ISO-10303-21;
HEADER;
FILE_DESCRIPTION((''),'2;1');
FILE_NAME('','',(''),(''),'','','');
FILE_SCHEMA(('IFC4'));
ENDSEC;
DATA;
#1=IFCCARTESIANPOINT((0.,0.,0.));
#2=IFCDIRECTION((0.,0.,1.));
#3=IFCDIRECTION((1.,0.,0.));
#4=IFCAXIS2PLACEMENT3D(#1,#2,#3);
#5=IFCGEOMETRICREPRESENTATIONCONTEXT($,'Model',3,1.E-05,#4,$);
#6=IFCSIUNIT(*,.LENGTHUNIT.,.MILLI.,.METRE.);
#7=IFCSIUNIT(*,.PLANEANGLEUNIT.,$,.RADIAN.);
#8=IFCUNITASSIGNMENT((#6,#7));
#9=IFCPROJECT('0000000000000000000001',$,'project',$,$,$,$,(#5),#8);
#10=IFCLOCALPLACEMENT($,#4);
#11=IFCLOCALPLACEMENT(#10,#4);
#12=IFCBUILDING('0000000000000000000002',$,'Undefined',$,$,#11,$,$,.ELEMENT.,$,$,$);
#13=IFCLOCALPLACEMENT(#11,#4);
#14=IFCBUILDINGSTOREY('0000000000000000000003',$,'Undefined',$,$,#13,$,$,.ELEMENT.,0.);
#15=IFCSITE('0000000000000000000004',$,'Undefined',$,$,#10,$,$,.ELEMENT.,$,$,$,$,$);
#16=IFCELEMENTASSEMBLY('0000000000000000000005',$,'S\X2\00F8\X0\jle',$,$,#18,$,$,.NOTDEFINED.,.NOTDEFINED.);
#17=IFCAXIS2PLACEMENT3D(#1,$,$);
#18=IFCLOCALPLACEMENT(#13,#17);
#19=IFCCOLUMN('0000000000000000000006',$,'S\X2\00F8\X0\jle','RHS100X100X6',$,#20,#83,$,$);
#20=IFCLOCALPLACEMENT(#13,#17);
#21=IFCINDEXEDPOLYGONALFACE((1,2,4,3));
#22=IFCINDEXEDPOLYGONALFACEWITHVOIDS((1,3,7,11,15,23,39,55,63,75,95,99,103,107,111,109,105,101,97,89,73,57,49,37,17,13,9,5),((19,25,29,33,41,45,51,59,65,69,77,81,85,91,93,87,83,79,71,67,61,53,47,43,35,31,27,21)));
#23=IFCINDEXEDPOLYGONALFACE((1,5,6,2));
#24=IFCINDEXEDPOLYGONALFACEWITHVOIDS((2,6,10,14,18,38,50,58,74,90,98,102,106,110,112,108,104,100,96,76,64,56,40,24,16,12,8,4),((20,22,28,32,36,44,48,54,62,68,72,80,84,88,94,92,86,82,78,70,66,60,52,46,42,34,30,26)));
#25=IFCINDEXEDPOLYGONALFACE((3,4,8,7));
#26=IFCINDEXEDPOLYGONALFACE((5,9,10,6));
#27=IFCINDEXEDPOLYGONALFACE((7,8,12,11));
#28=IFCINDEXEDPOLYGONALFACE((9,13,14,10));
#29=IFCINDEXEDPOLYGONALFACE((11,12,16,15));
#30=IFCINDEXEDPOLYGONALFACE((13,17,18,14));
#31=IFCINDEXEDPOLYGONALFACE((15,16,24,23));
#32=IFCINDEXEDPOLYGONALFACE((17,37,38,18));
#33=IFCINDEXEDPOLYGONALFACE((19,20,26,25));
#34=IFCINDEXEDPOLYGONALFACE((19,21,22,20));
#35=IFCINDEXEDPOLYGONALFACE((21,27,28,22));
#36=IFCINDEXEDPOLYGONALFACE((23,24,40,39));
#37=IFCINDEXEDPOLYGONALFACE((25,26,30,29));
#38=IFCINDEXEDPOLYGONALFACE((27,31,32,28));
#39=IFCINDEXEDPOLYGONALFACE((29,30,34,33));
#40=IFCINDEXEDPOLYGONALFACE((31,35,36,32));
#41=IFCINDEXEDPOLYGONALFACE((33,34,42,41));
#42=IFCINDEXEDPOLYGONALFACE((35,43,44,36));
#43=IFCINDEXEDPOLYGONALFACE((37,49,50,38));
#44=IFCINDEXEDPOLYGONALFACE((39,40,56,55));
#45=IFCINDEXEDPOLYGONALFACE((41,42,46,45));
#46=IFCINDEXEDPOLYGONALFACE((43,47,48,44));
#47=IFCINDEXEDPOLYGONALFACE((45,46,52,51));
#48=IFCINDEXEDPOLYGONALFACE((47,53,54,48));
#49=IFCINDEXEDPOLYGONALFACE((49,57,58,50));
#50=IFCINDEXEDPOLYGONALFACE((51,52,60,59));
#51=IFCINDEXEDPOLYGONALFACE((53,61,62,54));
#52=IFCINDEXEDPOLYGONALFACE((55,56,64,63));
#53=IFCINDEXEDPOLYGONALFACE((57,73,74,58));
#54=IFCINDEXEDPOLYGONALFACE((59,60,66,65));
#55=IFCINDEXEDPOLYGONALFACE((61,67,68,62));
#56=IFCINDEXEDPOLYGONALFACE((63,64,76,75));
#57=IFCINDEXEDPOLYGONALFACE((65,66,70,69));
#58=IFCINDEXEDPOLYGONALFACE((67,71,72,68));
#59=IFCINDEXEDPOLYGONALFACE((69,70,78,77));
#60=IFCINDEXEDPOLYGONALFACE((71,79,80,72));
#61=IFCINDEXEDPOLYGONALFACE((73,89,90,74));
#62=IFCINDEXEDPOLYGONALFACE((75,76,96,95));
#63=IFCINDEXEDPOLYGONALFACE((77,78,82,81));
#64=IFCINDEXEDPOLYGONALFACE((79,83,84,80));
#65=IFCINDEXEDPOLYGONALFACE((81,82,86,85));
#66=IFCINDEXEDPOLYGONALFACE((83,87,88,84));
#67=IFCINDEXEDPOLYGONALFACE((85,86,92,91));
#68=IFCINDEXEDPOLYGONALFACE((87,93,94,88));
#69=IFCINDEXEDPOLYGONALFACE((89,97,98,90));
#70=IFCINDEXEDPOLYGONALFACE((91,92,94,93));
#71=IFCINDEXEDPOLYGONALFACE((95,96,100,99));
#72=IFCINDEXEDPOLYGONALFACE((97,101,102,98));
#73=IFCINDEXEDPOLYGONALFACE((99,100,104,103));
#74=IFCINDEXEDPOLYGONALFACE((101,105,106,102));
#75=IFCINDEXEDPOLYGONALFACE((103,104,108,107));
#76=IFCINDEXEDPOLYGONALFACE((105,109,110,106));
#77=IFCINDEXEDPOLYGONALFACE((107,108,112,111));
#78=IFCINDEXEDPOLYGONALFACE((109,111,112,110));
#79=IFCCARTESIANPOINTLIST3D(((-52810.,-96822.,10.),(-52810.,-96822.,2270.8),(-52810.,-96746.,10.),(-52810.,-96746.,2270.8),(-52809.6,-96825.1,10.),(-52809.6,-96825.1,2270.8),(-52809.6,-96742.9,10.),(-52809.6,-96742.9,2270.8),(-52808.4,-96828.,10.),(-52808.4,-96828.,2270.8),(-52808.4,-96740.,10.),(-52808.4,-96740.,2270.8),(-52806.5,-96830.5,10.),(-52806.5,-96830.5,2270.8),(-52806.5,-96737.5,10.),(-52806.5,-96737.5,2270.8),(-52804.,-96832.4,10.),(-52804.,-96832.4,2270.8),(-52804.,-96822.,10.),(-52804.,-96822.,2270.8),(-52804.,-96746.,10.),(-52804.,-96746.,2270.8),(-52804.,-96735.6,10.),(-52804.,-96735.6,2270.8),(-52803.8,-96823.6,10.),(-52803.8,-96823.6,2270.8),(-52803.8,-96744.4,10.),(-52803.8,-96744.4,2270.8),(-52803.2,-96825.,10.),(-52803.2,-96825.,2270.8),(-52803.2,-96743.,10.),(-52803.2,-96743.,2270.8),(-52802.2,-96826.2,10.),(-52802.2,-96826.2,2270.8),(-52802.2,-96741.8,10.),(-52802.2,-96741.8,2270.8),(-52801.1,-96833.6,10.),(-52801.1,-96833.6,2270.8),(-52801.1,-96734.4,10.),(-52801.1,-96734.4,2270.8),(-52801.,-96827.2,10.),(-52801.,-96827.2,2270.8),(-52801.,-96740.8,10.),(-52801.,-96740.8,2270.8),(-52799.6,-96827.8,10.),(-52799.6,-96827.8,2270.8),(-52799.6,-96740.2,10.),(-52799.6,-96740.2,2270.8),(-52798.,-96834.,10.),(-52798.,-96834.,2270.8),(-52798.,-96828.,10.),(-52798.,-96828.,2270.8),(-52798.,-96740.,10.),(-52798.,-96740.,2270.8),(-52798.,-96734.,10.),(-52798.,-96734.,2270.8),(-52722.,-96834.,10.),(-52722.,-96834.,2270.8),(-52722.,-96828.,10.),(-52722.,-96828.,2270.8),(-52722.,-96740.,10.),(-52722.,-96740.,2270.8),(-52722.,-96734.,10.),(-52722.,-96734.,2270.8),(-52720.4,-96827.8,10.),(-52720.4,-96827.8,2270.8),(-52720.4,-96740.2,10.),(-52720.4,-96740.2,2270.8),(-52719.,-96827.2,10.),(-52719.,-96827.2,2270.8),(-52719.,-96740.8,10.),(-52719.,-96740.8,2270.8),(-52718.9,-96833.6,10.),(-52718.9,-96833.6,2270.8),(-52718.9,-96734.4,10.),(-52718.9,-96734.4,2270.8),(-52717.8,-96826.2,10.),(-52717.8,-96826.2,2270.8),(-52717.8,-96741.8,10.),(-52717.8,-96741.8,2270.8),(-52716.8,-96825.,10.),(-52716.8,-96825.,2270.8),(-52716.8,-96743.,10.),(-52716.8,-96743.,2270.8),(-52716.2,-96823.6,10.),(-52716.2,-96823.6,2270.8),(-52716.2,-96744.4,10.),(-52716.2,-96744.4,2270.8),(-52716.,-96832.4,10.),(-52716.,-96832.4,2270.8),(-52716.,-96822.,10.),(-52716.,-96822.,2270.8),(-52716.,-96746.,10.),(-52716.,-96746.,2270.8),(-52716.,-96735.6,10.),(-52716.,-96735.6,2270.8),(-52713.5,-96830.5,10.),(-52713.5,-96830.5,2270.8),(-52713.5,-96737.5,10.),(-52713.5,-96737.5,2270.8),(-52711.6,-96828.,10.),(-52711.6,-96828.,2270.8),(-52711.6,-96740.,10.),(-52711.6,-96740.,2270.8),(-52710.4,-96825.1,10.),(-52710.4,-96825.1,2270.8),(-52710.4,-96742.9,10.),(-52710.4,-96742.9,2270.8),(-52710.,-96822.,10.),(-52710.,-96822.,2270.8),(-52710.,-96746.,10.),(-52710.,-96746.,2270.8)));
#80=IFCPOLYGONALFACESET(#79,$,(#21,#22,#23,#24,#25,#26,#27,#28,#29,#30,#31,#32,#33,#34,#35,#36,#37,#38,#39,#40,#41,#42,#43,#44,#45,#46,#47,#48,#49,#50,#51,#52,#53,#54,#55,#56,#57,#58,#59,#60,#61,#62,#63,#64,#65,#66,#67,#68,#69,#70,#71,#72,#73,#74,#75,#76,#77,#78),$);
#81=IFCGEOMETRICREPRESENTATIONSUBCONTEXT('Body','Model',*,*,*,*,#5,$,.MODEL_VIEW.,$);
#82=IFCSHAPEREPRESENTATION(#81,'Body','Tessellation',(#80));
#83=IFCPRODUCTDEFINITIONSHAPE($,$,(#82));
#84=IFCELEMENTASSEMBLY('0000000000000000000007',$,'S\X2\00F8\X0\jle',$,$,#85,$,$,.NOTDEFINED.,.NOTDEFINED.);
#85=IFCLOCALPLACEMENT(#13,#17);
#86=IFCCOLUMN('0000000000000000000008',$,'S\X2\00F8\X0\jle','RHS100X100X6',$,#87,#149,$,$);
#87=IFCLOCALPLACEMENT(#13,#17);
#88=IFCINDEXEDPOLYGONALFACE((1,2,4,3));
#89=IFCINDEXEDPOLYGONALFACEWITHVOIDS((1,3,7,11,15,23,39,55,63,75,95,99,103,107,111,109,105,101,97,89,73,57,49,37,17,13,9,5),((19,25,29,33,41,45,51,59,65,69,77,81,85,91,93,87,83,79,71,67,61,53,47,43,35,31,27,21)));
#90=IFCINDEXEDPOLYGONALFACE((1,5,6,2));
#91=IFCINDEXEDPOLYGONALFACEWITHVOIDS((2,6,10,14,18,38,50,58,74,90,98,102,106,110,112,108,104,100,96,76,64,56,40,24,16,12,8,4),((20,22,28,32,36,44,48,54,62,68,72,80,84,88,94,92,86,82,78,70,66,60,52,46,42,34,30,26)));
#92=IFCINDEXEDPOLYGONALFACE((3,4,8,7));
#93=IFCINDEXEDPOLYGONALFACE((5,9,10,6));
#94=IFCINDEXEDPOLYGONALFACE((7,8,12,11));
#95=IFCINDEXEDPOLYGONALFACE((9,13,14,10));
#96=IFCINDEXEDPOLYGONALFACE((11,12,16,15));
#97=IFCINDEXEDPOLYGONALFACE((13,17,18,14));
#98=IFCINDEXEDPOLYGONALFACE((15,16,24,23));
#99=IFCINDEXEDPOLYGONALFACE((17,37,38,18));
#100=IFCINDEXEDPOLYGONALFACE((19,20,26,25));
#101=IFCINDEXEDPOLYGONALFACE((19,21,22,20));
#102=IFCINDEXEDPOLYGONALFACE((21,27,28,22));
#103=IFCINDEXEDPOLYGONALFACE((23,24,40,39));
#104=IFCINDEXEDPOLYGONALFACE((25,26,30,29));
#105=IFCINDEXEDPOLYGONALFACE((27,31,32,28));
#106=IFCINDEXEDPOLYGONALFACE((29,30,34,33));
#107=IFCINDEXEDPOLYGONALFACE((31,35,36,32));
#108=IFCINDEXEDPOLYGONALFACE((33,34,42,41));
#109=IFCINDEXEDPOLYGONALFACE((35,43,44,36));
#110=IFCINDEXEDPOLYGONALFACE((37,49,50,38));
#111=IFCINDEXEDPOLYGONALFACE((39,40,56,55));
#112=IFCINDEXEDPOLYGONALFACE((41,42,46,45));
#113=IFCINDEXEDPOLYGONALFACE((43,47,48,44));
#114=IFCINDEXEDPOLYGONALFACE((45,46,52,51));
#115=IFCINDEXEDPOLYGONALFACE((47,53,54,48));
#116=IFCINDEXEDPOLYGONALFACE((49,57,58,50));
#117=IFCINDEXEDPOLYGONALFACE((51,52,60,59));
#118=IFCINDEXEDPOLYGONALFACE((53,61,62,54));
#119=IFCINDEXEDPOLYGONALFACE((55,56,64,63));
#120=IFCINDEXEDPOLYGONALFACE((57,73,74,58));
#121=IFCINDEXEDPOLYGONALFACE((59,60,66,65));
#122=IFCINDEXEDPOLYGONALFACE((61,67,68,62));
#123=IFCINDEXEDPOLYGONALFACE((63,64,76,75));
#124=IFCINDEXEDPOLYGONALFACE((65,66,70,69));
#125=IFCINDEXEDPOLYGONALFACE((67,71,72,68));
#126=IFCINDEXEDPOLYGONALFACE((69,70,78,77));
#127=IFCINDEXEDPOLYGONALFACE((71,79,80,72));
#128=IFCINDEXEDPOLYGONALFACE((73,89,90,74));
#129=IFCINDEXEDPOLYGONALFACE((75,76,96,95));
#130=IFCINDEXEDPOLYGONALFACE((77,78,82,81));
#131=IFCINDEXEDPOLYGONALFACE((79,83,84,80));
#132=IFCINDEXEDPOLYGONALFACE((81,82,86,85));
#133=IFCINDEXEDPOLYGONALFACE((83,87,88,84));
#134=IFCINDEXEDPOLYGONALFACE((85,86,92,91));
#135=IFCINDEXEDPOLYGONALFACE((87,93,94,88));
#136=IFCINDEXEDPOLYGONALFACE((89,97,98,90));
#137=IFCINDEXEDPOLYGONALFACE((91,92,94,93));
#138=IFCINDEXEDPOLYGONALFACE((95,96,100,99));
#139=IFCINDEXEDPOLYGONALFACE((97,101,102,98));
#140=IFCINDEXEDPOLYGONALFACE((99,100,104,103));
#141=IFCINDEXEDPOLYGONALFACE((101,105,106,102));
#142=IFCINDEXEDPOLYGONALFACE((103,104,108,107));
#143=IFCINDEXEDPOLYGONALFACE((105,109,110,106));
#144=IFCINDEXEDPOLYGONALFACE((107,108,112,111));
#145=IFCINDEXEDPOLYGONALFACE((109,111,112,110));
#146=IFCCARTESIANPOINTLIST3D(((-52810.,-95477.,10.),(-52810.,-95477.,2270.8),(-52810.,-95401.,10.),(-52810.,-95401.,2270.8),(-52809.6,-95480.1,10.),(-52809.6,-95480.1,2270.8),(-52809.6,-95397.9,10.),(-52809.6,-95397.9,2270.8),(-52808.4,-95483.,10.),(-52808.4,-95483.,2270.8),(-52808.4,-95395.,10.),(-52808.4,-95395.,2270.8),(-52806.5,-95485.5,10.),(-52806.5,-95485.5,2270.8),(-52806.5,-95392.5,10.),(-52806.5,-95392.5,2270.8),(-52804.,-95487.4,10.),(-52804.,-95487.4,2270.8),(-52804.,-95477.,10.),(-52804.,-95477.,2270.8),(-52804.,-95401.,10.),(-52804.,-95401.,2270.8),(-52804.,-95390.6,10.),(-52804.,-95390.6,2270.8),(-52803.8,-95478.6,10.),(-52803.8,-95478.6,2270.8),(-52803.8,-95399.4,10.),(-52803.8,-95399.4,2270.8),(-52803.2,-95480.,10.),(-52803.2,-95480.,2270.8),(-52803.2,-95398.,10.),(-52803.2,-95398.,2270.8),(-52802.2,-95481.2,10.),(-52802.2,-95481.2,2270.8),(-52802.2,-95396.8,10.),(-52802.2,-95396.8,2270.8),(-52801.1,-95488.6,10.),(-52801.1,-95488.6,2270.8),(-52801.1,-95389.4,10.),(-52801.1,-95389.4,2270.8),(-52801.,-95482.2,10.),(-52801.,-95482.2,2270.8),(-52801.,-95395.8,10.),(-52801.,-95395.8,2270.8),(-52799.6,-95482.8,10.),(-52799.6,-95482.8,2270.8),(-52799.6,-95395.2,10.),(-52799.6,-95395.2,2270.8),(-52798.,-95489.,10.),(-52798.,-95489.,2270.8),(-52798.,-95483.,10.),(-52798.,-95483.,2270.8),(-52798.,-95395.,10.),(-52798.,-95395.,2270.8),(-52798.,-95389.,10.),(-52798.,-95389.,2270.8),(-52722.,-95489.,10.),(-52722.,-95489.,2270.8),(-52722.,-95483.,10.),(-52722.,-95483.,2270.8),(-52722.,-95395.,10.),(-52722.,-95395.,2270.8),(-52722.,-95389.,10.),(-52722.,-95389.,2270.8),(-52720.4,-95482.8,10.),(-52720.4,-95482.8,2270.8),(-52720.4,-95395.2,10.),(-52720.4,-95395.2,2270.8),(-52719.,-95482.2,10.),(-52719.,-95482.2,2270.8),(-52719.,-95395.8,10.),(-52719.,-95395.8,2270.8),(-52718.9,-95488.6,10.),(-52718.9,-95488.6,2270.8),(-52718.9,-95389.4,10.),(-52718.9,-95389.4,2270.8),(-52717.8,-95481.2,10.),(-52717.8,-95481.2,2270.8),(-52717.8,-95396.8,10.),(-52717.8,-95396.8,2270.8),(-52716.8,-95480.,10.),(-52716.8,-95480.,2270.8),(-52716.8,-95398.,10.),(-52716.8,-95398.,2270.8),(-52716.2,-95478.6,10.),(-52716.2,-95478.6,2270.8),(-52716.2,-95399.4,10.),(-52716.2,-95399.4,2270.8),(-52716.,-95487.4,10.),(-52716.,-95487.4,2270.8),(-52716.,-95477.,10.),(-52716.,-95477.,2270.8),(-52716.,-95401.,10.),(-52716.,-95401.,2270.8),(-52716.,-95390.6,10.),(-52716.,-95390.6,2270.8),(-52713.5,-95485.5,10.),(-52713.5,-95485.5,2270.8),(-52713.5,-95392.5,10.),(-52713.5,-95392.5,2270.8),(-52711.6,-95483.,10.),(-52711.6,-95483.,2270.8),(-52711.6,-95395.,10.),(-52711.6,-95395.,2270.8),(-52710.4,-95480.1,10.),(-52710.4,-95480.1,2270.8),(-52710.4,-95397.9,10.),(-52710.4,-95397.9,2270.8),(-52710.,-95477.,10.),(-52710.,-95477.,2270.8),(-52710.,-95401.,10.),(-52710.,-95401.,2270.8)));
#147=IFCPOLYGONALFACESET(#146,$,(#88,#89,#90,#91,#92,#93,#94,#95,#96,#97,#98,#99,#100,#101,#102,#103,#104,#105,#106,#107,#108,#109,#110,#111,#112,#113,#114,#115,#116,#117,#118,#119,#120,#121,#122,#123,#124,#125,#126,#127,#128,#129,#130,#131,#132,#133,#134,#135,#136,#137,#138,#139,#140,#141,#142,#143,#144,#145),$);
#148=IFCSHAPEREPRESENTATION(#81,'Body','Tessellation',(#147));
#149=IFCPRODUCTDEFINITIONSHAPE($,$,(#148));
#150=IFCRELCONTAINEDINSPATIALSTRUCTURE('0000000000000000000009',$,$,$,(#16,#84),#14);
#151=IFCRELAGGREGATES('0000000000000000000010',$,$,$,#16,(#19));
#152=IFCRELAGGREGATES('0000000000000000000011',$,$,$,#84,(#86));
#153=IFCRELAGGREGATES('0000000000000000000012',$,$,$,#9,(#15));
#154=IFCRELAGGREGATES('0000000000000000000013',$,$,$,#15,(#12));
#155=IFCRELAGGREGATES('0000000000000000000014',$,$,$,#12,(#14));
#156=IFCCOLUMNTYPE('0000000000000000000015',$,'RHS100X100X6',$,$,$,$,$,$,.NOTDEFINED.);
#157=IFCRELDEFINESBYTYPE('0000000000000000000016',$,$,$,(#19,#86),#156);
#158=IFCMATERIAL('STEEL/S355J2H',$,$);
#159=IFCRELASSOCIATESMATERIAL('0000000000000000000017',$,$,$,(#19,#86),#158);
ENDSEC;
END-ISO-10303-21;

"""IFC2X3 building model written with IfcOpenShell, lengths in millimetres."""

from ifc_helpers import new_model, si_unit, frame, origin_with_axes, origin_2d_with_axis, place, context, subcontext, project, spatial, hollow_rectangle, extrude, clip, halfspace, material, type_object, element, aggregate, save


model = new_model("IFC2X3")

# Units and contexts
model_context = context("Model", 3, precision=1e-05, world=origin_with_axes())
body_context = subcontext(model_context, "Body", "Model", "MODEL_VIEW")
ifc_project = project(units=[si_unit("LENGTHUNIT", "METRE", prefix="MILLI"), si_unit("PLANEANGLEUNIT", "RADIAN")], contexts=[model_context])

# Site, building, storey
site_placement = place(None, origin_with_axes())
site = spatial("IfcSite", under=ifc_project, at=site_placement, Name="Undefined", CompositionType="ELEMENT")
building_placement = place(site_placement, origin_with_axes())
building = spatial("IfcBuilding", under=site, at=building_placement, Name="Undefined", CompositionType="ELEMENT")
storey_placement = place(building_placement, origin_with_axes())
storey = spatial("IfcBuildingStorey", under=building, at=storey_placement, Name="Undefined", CompositionType="ELEMENT", Elevation=0.0)

# Element assemblies, columns
assembly_1_placement = place(storey_placement, origin_with_axes())
assembly_1 = element("IfcElementAssembly", 1, at=assembly_1_placement, inside=storey, Name="Søjle", AssemblyPlace="NOTDEFINED", PredefinedType="NOTDEFINED")
ifc_material_1 = material(Name="STEEL/S355J2H")
column_type = type_object("IfcColumnType", Name="RHS100X100X6", PredefinedType="NOTDEFINED")
column_1_placement = place(assembly_1_placement, frame((-52760.0, -96784.0, 0.0), z_axis=(0.0, 0.0, 1.0), x_axis=(0.0, -1.0, 0.0)))
column_1 = element("IfcColumn", 2, at=column_1_placement, type_object=column_type, material=ifc_material_1, Name="Søjle", Description="RHS100X100X6", context=body_context, shape_type="Clipping", body=[
    clip(clip(extrude(hollow_rectangle(XDim=100.0, YDim=100.0, WallThickness=6.0, InnerFilletRadius=6.0, OuterFilletRadius=12.0, at=origin_2d_with_axis()), frame((0.0, 0.0, 2380.8), z_axis=(0.0, 0.0, -1.0), x_axis=(0.0, 1.0, 0.0)), (0.0, 0.0, 1.0), 2380.8), halfspace(frame((50.0, 0.0, 2270.8), z_axis=(0.0, 0.0, -1.0), x_axis=(0.0, 1.0, 0.0)), True)), halfspace(frame((0.0, 50.0, 10.0), z_axis=(0.0, 0.0, 1.0), x_axis=(1.0, 0.0, 0.0)), True)),
])
assembly_2_placement = place(storey_placement, origin_with_axes())
assembly_2 = element("IfcElementAssembly", 3, at=assembly_2_placement, inside=storey, Name="Søjle", AssemblyPlace="NOTDEFINED", PredefinedType="NOTDEFINED")
column_2_placement = place(assembly_2_placement, frame((-52760.0, -95439.0, 0.0), z_axis=(0.0, 0.0, 1.0), x_axis=(0.0, -1.0, 0.0)))
column_2 = element("IfcColumn", 4, at=column_2_placement, type_object=column_type, material=ifc_material_1, Name="Søjle", Description="RHS100X100X6", context=body_context, shape_type="Clipping", body=[
    clip(clip(extrude(hollow_rectangle(XDim=100.0, YDim=100.0, WallThickness=6.0, InnerFilletRadius=6.0, OuterFilletRadius=12.0, at=origin_2d_with_axis()), frame((0.0, 0.0, 2380.8), z_axis=(0.0, 0.0, -1.0), x_axis=(0.0, 1.0, 0.0)), (0.0, 0.0, 1.0), 2380.8), halfspace(frame((50.0, 0.0, 2270.8), z_axis=(0.0, 0.0, -1.0), x_axis=(0.0, 1.0, 0.0)), True)), halfspace(frame((0.0, 50.0, 10.0), z_axis=(0.0, 0.0, 1.0), x_axis=(1.0, 0.0, 0.0)), True)),
])

aggregate(assembly_1, [column_1])
aggregate(assembly_2, [column_2])

save(model, "model.ifc")
